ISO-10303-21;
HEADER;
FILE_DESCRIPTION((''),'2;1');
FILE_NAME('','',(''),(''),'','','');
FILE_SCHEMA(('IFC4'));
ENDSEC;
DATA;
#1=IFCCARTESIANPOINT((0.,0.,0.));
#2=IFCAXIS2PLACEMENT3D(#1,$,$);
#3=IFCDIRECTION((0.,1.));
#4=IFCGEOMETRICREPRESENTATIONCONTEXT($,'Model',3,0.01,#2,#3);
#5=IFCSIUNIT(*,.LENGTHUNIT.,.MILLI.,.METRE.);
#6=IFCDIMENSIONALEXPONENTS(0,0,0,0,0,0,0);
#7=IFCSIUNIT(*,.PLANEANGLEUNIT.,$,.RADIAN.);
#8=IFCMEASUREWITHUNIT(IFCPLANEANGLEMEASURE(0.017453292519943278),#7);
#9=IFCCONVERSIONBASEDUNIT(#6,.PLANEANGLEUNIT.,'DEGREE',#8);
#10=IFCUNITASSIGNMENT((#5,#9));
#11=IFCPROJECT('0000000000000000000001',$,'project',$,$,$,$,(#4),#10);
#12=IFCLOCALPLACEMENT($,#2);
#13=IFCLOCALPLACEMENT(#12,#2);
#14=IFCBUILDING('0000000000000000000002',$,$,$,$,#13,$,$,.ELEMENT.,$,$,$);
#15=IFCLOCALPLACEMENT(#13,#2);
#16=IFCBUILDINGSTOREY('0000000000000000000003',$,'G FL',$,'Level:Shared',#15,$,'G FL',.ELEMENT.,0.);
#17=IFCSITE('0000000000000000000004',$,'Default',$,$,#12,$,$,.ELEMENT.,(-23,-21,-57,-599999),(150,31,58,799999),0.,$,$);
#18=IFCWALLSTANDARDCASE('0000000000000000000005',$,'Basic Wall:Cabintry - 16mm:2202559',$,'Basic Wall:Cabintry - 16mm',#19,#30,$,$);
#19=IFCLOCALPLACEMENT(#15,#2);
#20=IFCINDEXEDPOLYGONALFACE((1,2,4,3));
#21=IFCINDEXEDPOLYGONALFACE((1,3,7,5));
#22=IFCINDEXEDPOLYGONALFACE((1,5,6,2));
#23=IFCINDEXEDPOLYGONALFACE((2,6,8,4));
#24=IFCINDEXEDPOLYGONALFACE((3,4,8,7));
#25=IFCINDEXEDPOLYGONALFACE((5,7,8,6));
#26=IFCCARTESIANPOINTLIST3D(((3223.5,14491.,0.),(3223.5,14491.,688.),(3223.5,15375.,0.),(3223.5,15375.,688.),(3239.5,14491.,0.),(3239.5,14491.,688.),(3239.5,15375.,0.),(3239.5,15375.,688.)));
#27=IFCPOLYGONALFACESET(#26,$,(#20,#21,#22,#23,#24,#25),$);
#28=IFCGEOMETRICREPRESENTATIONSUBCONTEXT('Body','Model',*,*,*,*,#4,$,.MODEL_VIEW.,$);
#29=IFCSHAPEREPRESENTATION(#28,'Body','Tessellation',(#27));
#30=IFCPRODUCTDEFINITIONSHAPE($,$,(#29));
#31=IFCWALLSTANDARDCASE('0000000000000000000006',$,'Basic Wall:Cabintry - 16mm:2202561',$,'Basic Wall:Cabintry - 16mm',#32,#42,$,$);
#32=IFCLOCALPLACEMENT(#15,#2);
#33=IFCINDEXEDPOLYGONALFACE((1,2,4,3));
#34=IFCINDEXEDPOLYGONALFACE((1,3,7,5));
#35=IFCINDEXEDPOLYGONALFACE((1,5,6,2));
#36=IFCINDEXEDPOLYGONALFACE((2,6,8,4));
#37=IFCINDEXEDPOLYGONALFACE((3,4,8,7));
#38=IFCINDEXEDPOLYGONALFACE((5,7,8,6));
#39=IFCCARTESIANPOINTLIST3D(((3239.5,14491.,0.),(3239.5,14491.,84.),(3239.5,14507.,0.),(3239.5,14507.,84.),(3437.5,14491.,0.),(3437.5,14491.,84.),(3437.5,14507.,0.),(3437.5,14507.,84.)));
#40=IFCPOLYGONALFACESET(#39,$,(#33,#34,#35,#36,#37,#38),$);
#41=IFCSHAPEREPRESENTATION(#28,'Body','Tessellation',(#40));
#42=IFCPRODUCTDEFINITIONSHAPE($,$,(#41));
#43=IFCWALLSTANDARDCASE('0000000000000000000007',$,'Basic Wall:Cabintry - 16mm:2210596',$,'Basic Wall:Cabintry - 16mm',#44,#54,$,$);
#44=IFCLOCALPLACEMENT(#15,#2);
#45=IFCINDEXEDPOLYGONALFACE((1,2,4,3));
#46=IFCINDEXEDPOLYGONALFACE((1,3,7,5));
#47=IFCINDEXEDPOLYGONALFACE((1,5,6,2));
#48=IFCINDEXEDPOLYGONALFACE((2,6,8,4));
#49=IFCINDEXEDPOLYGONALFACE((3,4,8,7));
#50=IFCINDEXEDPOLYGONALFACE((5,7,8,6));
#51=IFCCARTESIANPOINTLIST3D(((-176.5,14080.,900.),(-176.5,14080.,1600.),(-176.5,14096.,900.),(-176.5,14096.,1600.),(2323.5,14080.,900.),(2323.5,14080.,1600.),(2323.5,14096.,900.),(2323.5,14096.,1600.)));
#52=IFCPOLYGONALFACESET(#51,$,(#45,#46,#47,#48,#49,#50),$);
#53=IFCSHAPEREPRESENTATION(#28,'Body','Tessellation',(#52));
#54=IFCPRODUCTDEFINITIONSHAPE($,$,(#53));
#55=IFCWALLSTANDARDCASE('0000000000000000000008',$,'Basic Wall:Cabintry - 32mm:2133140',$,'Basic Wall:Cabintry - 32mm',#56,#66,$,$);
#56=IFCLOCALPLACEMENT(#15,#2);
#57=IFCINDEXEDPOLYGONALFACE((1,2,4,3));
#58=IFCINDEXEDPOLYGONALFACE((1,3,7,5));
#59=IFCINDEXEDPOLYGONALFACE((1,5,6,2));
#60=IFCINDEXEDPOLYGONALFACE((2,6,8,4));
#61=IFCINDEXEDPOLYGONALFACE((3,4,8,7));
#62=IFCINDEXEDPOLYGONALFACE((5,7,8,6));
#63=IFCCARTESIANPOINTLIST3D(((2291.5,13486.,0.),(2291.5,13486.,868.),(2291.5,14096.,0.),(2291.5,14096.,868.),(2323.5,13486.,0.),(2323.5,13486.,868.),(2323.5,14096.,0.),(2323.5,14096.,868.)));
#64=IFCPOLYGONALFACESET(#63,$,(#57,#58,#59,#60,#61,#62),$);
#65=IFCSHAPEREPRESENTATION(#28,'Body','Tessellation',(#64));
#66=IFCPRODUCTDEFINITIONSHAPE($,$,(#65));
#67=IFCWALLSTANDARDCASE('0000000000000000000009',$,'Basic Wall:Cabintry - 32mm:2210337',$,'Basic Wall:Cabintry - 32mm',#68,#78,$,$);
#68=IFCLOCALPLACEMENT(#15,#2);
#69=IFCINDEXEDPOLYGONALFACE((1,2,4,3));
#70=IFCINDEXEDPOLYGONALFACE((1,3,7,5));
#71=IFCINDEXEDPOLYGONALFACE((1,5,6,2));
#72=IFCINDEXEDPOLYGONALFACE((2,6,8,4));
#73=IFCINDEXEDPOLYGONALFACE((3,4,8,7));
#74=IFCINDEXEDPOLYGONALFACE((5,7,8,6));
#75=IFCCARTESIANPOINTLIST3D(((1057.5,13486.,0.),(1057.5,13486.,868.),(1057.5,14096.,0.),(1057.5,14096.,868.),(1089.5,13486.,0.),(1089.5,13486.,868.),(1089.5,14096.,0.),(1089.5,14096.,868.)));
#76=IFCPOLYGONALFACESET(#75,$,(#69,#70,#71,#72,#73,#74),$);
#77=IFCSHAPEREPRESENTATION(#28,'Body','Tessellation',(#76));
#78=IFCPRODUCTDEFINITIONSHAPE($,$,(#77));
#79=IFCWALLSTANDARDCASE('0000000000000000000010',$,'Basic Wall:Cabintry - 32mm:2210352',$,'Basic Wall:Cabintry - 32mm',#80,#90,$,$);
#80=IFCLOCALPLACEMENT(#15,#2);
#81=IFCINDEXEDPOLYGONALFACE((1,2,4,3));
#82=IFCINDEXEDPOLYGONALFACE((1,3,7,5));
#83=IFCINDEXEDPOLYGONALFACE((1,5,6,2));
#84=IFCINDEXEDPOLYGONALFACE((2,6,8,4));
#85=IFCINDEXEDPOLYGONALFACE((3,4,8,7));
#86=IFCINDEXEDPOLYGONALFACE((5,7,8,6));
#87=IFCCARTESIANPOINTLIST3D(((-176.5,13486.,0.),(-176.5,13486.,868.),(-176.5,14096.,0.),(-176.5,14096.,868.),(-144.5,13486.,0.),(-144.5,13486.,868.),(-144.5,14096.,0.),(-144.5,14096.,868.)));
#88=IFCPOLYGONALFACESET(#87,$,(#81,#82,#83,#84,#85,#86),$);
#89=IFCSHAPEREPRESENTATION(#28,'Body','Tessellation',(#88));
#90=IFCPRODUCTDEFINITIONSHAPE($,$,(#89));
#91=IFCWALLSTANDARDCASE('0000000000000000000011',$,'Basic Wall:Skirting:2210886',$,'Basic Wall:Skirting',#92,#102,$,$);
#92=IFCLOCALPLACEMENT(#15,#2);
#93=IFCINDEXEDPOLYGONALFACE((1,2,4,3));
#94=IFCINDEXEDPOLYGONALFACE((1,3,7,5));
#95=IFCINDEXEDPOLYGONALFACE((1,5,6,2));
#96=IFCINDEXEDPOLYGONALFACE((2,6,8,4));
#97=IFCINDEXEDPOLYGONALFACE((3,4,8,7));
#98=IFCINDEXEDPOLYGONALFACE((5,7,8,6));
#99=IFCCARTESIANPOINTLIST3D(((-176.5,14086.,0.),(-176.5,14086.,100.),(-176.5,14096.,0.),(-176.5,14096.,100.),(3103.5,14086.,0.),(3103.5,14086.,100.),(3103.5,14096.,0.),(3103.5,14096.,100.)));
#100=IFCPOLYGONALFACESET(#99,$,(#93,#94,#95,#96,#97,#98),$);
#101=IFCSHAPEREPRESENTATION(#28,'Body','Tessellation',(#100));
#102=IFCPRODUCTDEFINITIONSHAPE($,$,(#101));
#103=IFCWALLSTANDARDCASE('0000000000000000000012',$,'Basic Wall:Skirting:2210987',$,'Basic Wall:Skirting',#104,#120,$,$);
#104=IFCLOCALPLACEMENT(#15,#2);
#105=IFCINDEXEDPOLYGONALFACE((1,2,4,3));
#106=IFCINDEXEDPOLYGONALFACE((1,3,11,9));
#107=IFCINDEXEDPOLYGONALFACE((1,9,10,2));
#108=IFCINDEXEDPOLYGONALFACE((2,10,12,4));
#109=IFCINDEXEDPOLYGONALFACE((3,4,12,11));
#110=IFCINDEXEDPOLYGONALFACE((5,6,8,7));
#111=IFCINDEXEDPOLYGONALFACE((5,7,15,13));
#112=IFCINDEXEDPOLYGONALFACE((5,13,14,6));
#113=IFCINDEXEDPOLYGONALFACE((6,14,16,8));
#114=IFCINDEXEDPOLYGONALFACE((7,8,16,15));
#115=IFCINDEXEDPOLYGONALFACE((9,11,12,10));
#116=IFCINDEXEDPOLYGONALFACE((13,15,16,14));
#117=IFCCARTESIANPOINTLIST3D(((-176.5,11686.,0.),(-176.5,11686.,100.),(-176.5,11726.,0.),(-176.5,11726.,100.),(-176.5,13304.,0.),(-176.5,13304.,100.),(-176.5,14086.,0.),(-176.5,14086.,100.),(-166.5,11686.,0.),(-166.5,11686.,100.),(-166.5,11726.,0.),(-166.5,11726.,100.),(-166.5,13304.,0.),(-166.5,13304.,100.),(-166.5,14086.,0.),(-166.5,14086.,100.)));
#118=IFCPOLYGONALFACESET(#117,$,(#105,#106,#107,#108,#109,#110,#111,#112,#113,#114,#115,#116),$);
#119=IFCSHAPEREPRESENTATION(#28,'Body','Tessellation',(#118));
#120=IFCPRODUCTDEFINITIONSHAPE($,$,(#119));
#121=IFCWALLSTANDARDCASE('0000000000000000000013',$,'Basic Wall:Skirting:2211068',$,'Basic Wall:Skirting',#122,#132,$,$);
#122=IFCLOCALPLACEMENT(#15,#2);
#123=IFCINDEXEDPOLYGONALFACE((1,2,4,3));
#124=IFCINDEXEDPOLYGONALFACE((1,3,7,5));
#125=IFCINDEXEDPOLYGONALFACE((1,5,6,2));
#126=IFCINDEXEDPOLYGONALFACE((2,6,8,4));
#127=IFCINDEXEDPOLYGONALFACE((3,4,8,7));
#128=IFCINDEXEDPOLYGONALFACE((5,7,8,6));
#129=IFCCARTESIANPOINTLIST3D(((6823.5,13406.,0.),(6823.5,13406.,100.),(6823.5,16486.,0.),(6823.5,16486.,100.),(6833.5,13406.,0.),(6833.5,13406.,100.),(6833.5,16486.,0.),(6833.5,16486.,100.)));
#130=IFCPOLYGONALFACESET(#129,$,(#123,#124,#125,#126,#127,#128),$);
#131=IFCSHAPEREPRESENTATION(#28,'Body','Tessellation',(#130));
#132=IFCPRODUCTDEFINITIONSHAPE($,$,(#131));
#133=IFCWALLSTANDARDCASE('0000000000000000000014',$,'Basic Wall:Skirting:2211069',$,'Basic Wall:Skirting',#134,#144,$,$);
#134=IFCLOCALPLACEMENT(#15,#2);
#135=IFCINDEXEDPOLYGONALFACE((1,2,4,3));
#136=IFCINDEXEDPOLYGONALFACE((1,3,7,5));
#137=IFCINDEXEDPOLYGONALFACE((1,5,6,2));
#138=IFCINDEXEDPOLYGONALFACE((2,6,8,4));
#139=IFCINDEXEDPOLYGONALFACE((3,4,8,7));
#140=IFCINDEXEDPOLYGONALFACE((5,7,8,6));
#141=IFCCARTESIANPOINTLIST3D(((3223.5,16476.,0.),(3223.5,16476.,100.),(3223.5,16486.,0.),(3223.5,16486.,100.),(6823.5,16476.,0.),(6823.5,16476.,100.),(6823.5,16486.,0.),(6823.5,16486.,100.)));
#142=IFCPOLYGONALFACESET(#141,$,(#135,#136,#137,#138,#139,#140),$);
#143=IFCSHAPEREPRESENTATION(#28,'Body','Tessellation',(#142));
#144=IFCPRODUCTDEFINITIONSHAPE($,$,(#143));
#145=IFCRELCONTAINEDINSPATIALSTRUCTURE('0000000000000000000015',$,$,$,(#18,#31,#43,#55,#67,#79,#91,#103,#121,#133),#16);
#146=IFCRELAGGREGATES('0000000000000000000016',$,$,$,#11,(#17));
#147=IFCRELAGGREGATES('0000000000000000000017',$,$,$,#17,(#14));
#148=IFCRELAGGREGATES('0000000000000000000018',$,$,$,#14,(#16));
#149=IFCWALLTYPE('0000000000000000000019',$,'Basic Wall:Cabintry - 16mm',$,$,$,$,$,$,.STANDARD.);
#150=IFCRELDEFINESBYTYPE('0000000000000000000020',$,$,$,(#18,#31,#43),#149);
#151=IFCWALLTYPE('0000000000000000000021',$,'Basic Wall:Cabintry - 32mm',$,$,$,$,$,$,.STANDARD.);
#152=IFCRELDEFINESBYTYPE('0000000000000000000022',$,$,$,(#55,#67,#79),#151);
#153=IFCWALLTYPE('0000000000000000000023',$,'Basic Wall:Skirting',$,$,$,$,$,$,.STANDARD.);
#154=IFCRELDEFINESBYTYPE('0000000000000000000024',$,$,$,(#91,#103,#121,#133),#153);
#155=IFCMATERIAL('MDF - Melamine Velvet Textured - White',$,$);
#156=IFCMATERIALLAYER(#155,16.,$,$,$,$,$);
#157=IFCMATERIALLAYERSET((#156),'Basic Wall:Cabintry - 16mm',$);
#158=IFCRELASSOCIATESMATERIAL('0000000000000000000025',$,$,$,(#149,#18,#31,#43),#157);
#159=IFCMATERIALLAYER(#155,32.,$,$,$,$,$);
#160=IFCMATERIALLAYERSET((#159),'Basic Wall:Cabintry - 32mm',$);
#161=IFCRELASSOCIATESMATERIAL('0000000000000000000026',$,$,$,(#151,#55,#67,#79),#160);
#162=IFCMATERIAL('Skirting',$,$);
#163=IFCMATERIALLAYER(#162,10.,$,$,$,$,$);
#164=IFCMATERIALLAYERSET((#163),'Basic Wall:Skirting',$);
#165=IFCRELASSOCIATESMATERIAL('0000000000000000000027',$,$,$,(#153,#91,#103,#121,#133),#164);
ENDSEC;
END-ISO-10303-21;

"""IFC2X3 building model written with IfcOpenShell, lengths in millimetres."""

from ifc_helpers import new_model, entity, si_unit, converted_unit, direction, frame, frame_2d, origin, place, context, subcontext, project, spatial, polyline, rectangle, extrude, clip, bounded_halfspace, material, layer, layer_set, layer_usage, type_object, element, save


model = new_model("IFC2X3")

# Units and contexts
model_context = context("Model", 3, precision=0.01, world=origin(), true_north=direction((0.0, 1.0)))
body_context = subcontext(model_context, "Body", "Model", "MODEL_VIEW")
ifc_project = project(units=[si_unit("LENGTHUNIT", "METRE", prefix="MILLI"), converted_unit("PLANEANGLEUNIT", "DEGREE", entity("IfcPlaneAngleMeasure", 0.017453292519943278), si_unit("PLANEANGLEUNIT", "RADIAN"), dimensions=[0, 0, 0, 0, 0, 0, 0])], contexts=[model_context])

# Site, building, storey
site_placement = place(None, origin())
site = spatial("IfcSite", under=ifc_project, at=site_placement, Name="Default", CompositionType="ELEMENT", RefLatitude=(-23, -21, -57, -599999), RefLongitude=(150, 31, 58, 799999), RefElevation=0.0)
building_placement = place(site_placement, origin())
building = spatial("IfcBuilding", under=site, at=building_placement, CompositionType="ELEMENT")
storey_placement = place(building_placement, origin())
storey = spatial("IfcBuildingStorey", under=building, at=storey_placement, Name="G FL", ObjectType="Level:Shared", LongName="G FL", CompositionType="ELEMENT", Elevation=0.0)

# Shared definitions
ifc_material_1 = material(Name="MDF - Melamine Velvet Textured - White")

# Walls
ifc_layer_1 = layer(ifc_material_1, 16.0)
ifc_layer_set_1 = layer_set([ifc_layer_1], Name="Basic Wall:Cabintry - 16mm")
wall_type_1 = type_object("IfcWallType", Name="Basic Wall:Cabintry - 16mm", PredefinedType="STANDARD", material=ifc_layer_set_1)
ifc_layer_usage_1 = layer_usage(ifc_layer_set_1, "AXIS2", "POSITIVE", -8.0)
wall_1_placement = place(storey_placement, frame((3231.5, 15375.0, 0.0), z_axis=(0.0, 0.0, 1.0), x_axis=(0.0, -1.0, 0.0)))
element("IfcWallStandardCase", 1, at=wall_1_placement, inside=storey, type_object=wall_type_1, material=ifc_layer_usage_1, Name="Basic Wall:Cabintry - 16mm:2202559", ObjectType="Basic Wall:Cabintry - 16mm", context=body_context, shape_type="SweptSolid", body=[
    extrude(rectangle(XDim=884.0, YDim=16.0, at=frame_2d((442.0, 0.0), x_axis=(-1.0, 0.0))), origin(), (0.0, 0.0, 1.0), 688.0),
])
ifc_layer_usage_2 = layer_usage(ifc_layer_set_1, "AXIS2", "NEGATIVE", 8.0)
wall_2_placement = place(storey_placement, frame((3239.5, 14499.0, 0.0)))
element("IfcWallStandardCase", 2, at=wall_2_placement, inside=storey, type_object=wall_type_1, material=ifc_layer_usage_2, Name="Basic Wall:Cabintry - 16mm:2202561", ObjectType="Basic Wall:Cabintry - 16mm", context=body_context, shape_type="Clipping", body=[
    clip(extrude(rectangle(XDim=198.0, YDim=16.0, at=frame_2d((99.0, 0.0), x_axis=(-1.0, 0.0))), origin(), (0.0, 0.0, 1.0), 84.0), bounded_halfspace(frame((0.0, -8.0, 84.0), z_axis=(0.0, 0.0, -1.0), x_axis=(-1.0, 0.0, 0.0)), True, frame((0.0, -8.0, 84.0)), polyline([(0.0, 0.0), (198.0, 0.0), (198.0, 16.0), (0.0, 16.0), (0.0, 0.0)]))),
])
ifc_layer_usage_3 = layer_usage(ifc_layer_set_1, "AXIS2", "NEGATIVE", 8.0)
wall_3_placement = place(storey_placement, frame((2323.5, 14088.0, 900.0), z_axis=(0.0, 0.0, 1.0), x_axis=(-1.0, 0.0, 0.0)))
element("IfcWallStandardCase", 3, at=wall_3_placement, inside=storey, type_object=wall_type_1, material=ifc_layer_usage_3, Name="Basic Wall:Cabintry - 16mm:2210596", ObjectType="Basic Wall:Cabintry - 16mm", context=body_context, shape_type="SweptSolid", body=[
    extrude(rectangle(XDim=2500.0, YDim=16.0, at=frame_2d((1250.0, 0.0), x_axis=(-1.0, 0.0))), origin(), (0.0, 0.0, 1.0), 700.0),
])
ifc_layer_2 = layer(ifc_material_1, 32.0)
ifc_layer_set_2 = layer_set([ifc_layer_2], Name="Basic Wall:Cabintry - 32mm")
ifc_layer_usage_4 = layer_usage(ifc_layer_set_2, "AXIS2", "NEGATIVE", 16.0)
wall_type_2 = type_object("IfcWallType", Name="Basic Wall:Cabintry - 32mm", PredefinedType="STANDARD", material=ifc_layer_set_2)
wall_4_placement = place(storey_placement, frame((2307.5, 14096.0, 0.0), z_axis=(0.0, 0.0, 1.0), x_axis=(0.0, -1.0, 0.0)))
element("IfcWallStandardCase", 4, at=wall_4_placement, inside=storey, type_object=wall_type_2, material=ifc_layer_usage_4, Name="Basic Wall:Cabintry - 32mm:2133140", ObjectType="Basic Wall:Cabintry - 32mm", context=body_context, shape_type="Clipping", body=[
    clip(extrude(rectangle(XDim=610.0, YDim=32.0, at=frame_2d((305.0, 0.0), x_axis=(-1.0, 0.0))), origin(), (0.0, 0.0, 1.0), 868.0), bounded_halfspace(frame((0.0, -16.0, 868.0), z_axis=(0.0, 0.0, -1.0), x_axis=(1.0, 0.0, 0.0)), True, frame((0.0, -16.0, 868.0)), polyline([(0.0, 0.0), (610.0, 0.0), (610.0, 32.0), (0.0, 32.0), (0.0, 0.0)]))),
])
ifc_layer_usage_5 = layer_usage(ifc_layer_set_2, "AXIS2", "NEGATIVE", 16.0)
wall_5_placement = place(storey_placement, frame((1073.5, 14096.0, 0.0), z_axis=(0.0, 0.0, 1.0), x_axis=(0.0, -1.0, 0.0)))
element("IfcWallStandardCase", 5, at=wall_5_placement, inside=storey, type_object=wall_type_2, material=ifc_layer_usage_5, Name="Basic Wall:Cabintry - 32mm:2210337", ObjectType="Basic Wall:Cabintry - 32mm", context=body_context, shape_type="Clipping", body=[
    clip(extrude(rectangle(XDim=610.0, YDim=32.0, at=frame_2d((305.0, 0.0), x_axis=(-1.0, 0.0))), origin(), (0.0, 0.0, 1.0), 868.0), bounded_halfspace(frame((0.0, -16.0, 868.0), z_axis=(0.0, 0.0, -1.0), x_axis=(1.0, 0.0, 0.0)), True, frame((0.0, -16.0, 868.0)), polyline([(0.0, 0.0), (610.0, 0.0), (610.0, 32.0), (0.0, 32.0), (0.0, 0.0)]))),
])
ifc_layer_usage_6 = layer_usage(ifc_layer_set_2, "AXIS2", "NEGATIVE", 16.0)
wall_6_placement = place(storey_placement, frame((-160.5, 14096.0, 0.0), z_axis=(0.0, 0.0, 1.0), x_axis=(0.0, -1.0, 0.0)))
element("IfcWallStandardCase", 6, at=wall_6_placement, inside=storey, type_object=wall_type_2, material=ifc_layer_usage_6, Name="Basic Wall:Cabintry - 32mm:2210352", ObjectType="Basic Wall:Cabintry - 32mm", context=body_context, shape_type="Clipping", body=[
    clip(extrude(rectangle(XDim=610.0, YDim=32.0, at=frame_2d((305.0, 0.0), x_axis=(-1.0, 0.0))), origin(), (0.0, 0.0, 1.0), 868.0), bounded_halfspace(frame((0.0, -16.0, 868.0), z_axis=(0.0, 0.0, -1.0), x_axis=(1.0, 0.0, 0.0)), True, frame((0.0, -16.0, 868.0)), polyline([(0.0, 0.0), (610.0, 0.0), (610.0, 32.0), (0.0, 32.0), (0.0, 0.0)]))),
])
ifc_material_2 = material(Name="Skirting")
ifc_layer_3 = layer(ifc_material_2, 10.0)
ifc_layer_set_3 = layer_set([ifc_layer_3], Name="Basic Wall:Skirting")
ifc_layer_usage_7 = layer_usage(ifc_layer_set_3, "AXIS2", "NEGATIVE", 5.0)
wall_type_3 = type_object("IfcWallType", Name="Basic Wall:Skirting", PredefinedType="STANDARD", material=ifc_layer_set_3)
wall_7_placement = place(storey_placement, frame((-176.5, 14091.0, 0.0)))
element("IfcWallStandardCase", 7, at=wall_7_placement, inside=storey, type_object=wall_type_3, material=ifc_layer_usage_7, Name="Basic Wall:Skirting:2210886", ObjectType="Basic Wall:Skirting", context=body_context, shape_type="SweptSolid", body=[
    extrude(rectangle(XDim=3280.0, YDim=10.0, at=frame_2d((1640.0, 0.0), x_axis=(-1.0, 0.0))), origin(), (0.0, 0.0, 1.0), 100.0),
])

# Wall, opening
ifc_layer_usage_8 = layer_usage(ifc_layer_set_3, "AXIS2", "POSITIVE", -5.0)
wall_8_placement = place(storey_placement, frame((-171.5, 14086.0, 0.0), z_axis=(0.0, 0.0, 1.0), x_axis=(0.0, -1.0, 0.0)))
wall_8 = element("IfcWallStandardCase", 8, at=wall_8_placement, inside=storey, type_object=wall_type_3, material=ifc_layer_usage_8, Name="Basic Wall:Skirting:2210987", ObjectType="Basic Wall:Skirting", context=body_context, shape_type="SweptSolid", body=[
    extrude(rectangle(XDim=2400.0, YDim=10.0, at=frame_2d((1200.0, 0.0), x_axis=(-1.0, 0.0))), origin(), (0.0, 0.0, 1.0), 100.0),
])
opening_1_placement = place(wall_8_placement, origin())
element("IfcOpeningElement", 9, at=opening_1_placement, cuts=wall_8, ObjectType="Opening", context=body_context, shape_type="SweptSolid", body=[
    extrude(rectangle(XDim=2400.0, YDim=1578.0, at=frame_2d((0.0, 0.0), x_axis=(0.0, 1.0))), frame((1571.0, -1769.0, 1200.0), z_axis=(0.0, 1.0, 0.0), x_axis=(-1.0, 0.0, 0.0)), (0.0, 0.0, 1.0), 3048.0),
])

# Walls
ifc_layer_usage_9 = layer_usage(ifc_layer_set_3, "AXIS2", "NEGATIVE", 5.0)
wall_9_placement = place(storey_placement, frame((6828.5, 16486.0, 0.0), z_axis=(0.0, 0.0, 1.0), x_axis=(0.0, -1.0, 0.0)))
element("IfcWallStandardCase", 10, at=wall_9_placement, inside=storey, type_object=wall_type_3, material=ifc_layer_usage_9, Name="Basic Wall:Skirting:2211068", ObjectType="Basic Wall:Skirting", context=body_context, shape_type="SweptSolid", body=[
    extrude(rectangle(XDim=3080.0, YDim=10.0, at=frame_2d((1540.0, 0.0), x_axis=(-1.0, 0.0))), origin(), (0.0, 0.0, 1.0), 100.0),
])
ifc_layer_usage_10 = layer_usage(ifc_layer_set_3, "AXIS2", "NEGATIVE", 5.0)
wall_10_placement = place(storey_placement, frame((3223.5, 16481.0, 0.0)))
element("IfcWallStandardCase", 11, at=wall_10_placement, inside=storey, type_object=wall_type_3, material=ifc_layer_usage_10, Name="Basic Wall:Skirting:2211069", ObjectType="Basic Wall:Skirting", context=body_context, shape_type="SweptSolid", body=[
    extrude(rectangle(XDim=3600.0, YDim=10.0, at=frame_2d((1800.0, 0.0), x_axis=(-1.0, 0.0))), origin(), (0.0, 0.0, 1.0), 100.0),
])

save(model, "model.ifc")
